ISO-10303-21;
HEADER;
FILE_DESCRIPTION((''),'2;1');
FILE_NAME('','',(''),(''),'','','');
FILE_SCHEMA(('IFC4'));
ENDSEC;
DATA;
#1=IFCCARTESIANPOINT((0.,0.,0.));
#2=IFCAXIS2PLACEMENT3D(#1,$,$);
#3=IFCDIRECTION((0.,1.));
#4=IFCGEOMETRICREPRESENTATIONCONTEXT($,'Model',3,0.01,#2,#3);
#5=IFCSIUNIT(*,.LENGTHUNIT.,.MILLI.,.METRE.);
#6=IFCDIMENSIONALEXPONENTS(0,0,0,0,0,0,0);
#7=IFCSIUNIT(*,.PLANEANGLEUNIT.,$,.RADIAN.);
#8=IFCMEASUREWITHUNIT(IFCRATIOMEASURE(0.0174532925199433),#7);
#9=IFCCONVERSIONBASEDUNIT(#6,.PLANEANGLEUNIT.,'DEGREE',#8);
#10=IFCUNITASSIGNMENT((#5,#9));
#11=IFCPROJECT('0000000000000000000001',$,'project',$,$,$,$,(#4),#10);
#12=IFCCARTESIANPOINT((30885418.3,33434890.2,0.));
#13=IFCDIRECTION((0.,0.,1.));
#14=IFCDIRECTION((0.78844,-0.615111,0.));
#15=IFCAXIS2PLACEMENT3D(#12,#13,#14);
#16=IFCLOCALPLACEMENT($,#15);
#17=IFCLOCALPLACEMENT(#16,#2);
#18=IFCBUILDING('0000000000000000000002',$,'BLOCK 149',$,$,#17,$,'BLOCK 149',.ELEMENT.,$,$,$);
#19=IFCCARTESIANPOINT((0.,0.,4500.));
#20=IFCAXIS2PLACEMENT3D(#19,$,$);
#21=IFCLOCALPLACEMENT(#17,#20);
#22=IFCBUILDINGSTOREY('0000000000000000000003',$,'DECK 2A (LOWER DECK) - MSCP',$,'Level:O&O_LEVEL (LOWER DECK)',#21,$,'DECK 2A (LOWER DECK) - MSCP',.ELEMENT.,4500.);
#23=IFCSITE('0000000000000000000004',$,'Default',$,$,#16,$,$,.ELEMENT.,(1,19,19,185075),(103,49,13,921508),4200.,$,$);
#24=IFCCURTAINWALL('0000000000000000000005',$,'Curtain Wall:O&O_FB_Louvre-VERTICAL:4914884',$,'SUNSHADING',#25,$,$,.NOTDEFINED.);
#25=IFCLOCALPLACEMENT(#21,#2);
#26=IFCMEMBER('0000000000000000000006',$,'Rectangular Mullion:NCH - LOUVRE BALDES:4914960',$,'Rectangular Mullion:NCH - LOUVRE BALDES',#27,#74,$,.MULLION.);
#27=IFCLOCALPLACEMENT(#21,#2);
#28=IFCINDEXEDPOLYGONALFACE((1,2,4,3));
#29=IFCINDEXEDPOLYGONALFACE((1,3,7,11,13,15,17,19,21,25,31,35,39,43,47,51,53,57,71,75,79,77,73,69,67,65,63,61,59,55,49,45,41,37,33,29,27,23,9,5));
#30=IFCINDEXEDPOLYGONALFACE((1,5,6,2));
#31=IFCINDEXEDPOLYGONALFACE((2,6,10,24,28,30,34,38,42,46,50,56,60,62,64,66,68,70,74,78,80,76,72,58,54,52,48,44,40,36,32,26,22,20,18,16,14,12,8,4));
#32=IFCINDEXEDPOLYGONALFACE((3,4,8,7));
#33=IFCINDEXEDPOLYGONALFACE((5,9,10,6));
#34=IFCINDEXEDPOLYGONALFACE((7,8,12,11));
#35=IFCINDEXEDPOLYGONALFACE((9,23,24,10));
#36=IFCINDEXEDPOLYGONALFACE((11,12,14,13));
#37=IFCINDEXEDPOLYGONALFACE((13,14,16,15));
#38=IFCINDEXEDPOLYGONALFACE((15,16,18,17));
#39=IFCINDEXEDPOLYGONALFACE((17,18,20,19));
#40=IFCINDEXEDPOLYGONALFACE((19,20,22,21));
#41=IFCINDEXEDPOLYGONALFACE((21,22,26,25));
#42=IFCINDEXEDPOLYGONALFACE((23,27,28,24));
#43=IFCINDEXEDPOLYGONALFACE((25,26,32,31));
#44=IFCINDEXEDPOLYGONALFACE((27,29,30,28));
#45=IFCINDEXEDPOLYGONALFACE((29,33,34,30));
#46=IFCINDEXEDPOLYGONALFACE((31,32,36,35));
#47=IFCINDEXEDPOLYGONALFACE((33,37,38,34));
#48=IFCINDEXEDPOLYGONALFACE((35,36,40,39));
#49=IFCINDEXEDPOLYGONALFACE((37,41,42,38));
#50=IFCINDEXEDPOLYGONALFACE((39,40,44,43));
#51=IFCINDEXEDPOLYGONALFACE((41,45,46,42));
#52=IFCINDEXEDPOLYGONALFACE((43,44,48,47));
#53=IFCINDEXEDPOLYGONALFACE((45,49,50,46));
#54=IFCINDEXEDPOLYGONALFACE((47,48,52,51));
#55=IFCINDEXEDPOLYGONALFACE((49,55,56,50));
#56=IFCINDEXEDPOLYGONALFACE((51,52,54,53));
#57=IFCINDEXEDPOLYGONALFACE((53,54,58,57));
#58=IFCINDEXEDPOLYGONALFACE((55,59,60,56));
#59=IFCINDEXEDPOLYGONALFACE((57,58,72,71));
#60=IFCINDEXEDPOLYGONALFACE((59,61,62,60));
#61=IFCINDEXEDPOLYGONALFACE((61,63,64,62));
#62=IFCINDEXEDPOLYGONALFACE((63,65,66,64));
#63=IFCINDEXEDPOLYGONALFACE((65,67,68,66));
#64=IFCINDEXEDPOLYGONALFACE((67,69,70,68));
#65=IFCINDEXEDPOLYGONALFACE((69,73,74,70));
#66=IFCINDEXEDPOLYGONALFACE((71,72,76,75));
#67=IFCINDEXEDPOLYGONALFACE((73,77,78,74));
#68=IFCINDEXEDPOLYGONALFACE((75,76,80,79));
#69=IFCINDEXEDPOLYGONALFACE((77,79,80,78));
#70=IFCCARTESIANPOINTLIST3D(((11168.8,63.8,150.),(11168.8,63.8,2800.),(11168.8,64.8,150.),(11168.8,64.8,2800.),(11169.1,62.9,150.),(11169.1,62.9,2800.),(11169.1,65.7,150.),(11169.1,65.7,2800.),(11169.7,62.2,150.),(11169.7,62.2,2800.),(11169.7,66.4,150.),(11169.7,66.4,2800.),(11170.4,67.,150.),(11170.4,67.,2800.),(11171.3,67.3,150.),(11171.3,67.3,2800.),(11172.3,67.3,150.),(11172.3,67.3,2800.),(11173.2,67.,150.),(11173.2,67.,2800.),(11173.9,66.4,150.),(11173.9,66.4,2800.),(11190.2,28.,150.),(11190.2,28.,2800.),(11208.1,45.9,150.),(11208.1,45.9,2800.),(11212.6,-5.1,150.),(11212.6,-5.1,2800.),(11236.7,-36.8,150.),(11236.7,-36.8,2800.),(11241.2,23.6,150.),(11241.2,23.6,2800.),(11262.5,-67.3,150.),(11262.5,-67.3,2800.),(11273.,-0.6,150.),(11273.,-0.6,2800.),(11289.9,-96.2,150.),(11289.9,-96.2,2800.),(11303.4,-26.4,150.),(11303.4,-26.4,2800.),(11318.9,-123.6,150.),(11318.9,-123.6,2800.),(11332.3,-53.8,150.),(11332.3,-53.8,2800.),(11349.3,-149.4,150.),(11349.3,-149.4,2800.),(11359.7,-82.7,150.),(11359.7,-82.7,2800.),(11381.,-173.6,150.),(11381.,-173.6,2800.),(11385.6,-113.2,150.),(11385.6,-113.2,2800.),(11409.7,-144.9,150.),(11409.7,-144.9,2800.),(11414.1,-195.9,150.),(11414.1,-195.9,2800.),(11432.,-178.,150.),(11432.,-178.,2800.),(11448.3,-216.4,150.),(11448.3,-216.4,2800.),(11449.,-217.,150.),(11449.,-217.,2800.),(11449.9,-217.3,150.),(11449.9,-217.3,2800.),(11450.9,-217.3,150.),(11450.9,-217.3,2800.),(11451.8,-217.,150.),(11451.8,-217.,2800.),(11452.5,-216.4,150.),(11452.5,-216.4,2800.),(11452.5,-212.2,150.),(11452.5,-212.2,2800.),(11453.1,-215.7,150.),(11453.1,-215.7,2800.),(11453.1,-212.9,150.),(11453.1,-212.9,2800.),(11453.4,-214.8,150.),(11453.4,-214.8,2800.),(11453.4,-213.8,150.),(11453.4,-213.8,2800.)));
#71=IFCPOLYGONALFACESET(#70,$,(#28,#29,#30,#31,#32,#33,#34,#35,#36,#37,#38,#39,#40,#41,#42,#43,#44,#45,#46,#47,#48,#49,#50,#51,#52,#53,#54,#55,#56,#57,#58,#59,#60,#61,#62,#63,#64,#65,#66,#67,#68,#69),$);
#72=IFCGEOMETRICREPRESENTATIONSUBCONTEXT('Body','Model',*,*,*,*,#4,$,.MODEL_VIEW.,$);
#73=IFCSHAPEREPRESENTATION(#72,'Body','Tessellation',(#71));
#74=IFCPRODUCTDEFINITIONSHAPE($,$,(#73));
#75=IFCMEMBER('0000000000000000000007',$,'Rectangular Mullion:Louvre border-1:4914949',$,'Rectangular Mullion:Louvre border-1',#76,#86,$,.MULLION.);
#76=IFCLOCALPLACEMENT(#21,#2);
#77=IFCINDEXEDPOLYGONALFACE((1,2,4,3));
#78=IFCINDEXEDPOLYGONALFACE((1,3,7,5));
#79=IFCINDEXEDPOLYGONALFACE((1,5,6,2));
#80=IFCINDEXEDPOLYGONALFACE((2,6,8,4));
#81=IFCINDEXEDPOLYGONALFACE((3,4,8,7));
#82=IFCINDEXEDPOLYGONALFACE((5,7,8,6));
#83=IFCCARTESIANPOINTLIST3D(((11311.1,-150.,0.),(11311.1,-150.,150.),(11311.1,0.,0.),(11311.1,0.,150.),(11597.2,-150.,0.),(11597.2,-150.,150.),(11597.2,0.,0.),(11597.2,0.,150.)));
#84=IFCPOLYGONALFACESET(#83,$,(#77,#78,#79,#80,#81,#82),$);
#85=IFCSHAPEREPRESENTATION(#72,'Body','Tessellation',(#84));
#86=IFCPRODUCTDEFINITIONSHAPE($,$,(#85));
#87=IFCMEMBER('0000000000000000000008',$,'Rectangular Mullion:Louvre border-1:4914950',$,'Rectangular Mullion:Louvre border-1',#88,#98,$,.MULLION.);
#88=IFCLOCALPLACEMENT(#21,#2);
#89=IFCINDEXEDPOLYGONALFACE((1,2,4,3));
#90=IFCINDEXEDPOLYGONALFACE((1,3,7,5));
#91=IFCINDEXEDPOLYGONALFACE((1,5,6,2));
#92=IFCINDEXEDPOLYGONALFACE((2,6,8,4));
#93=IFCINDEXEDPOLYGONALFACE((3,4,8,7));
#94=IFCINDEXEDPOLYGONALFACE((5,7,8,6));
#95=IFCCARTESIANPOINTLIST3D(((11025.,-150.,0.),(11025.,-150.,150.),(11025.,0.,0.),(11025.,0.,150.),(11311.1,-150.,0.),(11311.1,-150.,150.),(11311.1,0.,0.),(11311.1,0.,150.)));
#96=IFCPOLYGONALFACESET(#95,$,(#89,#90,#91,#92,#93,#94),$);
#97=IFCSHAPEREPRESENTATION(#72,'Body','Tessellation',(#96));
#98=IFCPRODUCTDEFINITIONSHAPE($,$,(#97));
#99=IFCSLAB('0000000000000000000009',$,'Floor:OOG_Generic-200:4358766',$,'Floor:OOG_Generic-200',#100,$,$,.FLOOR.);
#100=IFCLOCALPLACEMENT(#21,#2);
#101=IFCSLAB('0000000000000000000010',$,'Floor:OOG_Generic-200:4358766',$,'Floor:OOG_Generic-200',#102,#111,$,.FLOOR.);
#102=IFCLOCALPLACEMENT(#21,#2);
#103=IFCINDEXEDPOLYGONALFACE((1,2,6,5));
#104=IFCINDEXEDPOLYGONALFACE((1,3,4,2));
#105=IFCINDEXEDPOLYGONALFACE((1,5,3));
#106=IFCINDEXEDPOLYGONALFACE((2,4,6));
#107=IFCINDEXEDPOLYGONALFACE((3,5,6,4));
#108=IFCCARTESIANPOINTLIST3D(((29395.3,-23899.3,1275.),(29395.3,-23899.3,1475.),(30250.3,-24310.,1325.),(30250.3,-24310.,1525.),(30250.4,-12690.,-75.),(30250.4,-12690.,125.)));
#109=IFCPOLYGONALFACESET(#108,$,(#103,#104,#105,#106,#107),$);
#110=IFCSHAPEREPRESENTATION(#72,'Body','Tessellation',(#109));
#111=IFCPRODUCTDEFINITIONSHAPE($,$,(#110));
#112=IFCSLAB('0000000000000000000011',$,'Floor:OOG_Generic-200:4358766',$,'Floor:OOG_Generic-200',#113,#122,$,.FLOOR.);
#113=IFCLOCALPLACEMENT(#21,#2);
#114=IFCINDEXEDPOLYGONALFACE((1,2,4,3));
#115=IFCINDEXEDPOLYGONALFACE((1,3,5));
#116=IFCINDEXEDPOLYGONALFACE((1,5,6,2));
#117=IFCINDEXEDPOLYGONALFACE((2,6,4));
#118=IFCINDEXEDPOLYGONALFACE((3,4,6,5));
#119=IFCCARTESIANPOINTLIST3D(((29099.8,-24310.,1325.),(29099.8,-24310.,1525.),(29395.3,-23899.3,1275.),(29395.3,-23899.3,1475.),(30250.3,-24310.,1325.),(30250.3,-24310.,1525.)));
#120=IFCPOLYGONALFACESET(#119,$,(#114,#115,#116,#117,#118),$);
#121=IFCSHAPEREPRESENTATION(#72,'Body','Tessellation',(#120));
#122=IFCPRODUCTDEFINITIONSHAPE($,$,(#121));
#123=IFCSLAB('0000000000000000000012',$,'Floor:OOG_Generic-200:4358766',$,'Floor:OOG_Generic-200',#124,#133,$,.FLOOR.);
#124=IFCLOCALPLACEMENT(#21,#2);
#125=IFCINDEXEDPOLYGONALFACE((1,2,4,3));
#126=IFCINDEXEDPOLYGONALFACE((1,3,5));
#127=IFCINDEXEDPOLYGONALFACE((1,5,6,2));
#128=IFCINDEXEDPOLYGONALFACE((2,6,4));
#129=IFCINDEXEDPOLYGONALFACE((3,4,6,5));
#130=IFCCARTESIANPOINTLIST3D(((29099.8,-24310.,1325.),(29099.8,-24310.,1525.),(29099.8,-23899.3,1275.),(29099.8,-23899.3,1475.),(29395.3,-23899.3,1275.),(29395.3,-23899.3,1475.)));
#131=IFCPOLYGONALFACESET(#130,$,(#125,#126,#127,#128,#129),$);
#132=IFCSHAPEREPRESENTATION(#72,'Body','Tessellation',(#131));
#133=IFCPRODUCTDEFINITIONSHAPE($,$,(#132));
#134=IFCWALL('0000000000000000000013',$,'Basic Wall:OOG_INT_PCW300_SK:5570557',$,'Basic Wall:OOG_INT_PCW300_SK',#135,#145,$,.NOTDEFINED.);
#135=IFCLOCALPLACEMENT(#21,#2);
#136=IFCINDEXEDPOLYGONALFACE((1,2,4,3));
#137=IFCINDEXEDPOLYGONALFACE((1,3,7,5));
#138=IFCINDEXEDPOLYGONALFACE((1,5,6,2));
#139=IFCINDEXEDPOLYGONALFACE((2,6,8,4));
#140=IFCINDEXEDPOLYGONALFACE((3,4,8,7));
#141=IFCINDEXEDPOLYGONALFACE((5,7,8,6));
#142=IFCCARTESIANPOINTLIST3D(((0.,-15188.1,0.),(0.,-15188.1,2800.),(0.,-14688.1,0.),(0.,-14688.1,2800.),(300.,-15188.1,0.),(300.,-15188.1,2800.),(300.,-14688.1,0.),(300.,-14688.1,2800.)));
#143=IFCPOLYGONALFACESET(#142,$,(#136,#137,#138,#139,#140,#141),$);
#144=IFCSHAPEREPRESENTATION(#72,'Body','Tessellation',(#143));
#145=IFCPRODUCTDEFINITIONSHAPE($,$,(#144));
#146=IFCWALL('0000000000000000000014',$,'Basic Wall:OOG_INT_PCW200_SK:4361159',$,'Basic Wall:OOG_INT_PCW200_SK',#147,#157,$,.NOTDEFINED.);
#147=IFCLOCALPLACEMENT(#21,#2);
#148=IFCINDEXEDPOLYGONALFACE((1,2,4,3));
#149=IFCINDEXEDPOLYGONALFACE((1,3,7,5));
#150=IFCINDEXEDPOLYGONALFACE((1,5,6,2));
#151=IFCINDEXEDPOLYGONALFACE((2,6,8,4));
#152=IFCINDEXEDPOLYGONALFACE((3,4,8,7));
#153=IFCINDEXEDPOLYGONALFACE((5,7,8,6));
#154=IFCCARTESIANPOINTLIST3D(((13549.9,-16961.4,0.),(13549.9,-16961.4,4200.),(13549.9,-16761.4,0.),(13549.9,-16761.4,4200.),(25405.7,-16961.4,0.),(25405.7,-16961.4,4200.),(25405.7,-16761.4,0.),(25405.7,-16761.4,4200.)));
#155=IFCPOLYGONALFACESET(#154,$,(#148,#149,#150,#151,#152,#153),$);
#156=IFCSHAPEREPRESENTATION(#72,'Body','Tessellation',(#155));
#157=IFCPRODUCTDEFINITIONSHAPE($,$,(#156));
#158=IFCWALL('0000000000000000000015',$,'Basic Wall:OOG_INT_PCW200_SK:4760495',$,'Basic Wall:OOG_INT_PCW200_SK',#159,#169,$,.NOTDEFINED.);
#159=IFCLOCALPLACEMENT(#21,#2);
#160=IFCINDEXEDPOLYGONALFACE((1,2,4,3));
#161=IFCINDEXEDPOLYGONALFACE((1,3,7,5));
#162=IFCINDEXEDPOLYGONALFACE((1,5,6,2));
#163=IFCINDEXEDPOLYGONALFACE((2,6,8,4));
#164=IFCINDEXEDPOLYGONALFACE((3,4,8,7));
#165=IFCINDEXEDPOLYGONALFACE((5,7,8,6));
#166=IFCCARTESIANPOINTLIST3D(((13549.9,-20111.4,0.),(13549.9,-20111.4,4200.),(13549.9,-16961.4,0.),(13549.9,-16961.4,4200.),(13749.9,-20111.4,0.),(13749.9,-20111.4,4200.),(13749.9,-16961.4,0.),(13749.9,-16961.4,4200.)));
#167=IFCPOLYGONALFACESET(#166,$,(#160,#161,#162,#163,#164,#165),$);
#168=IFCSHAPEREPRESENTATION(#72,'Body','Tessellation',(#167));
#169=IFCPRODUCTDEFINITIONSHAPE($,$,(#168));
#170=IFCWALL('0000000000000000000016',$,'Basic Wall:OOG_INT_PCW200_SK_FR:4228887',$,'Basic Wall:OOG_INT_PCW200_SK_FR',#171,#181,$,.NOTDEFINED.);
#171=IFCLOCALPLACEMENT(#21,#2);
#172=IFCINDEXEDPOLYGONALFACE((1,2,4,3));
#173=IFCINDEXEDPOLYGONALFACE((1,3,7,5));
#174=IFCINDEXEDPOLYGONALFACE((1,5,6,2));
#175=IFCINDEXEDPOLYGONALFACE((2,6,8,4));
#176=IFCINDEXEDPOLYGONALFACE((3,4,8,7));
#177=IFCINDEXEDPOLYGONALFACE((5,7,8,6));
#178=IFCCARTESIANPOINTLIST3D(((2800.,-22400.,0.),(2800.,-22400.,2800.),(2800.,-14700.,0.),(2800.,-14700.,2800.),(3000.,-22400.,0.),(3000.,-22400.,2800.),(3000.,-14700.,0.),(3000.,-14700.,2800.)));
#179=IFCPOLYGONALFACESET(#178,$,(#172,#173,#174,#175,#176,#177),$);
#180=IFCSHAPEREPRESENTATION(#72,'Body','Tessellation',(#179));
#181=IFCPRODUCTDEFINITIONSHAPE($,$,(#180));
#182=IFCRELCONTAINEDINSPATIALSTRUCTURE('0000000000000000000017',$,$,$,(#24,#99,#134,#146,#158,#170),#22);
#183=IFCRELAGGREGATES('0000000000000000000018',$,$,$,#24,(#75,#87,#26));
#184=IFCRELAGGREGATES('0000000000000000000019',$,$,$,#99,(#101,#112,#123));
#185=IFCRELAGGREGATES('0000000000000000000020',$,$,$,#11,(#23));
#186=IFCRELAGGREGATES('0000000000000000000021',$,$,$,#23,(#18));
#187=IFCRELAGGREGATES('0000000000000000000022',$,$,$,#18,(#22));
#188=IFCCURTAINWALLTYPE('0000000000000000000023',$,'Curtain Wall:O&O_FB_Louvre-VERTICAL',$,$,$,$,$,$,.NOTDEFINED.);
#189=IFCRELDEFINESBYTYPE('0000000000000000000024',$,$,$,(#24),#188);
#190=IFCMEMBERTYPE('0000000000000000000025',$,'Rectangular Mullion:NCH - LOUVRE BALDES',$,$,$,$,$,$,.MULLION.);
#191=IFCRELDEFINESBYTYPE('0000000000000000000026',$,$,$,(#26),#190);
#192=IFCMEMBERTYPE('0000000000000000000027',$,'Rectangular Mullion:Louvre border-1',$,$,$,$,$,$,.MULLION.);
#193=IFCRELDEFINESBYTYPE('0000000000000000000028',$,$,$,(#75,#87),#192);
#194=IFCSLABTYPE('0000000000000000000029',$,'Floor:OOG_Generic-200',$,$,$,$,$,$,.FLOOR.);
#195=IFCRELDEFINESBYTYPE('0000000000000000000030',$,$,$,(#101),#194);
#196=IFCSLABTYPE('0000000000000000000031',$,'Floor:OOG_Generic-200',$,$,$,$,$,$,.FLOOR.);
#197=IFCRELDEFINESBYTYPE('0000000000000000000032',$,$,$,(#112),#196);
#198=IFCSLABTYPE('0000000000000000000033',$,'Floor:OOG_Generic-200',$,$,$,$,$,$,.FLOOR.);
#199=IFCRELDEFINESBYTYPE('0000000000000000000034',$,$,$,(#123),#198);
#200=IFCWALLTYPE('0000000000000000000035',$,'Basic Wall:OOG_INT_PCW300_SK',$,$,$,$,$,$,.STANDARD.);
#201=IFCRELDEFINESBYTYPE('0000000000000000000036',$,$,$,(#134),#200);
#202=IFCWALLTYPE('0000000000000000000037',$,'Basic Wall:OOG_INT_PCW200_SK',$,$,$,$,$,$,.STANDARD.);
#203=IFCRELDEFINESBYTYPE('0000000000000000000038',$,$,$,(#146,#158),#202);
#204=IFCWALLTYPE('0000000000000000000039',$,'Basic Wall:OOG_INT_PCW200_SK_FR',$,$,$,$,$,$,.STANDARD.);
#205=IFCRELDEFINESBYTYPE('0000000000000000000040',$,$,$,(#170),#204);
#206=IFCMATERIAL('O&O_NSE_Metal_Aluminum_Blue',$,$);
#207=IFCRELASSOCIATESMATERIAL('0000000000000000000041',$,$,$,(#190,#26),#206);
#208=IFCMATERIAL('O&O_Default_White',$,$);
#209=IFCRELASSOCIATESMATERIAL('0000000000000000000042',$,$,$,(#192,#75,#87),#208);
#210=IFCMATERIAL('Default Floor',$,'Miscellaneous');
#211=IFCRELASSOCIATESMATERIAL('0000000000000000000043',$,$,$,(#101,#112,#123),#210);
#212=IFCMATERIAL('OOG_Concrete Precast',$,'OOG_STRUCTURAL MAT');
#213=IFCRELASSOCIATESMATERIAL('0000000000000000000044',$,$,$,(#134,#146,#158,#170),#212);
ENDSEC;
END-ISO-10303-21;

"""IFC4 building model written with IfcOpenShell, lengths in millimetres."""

from ifc_helpers import new_model, entity, si_unit, converted_unit, direction, frame, origin, place, context, subcontext, project, spatial, indexed_curve, outline, extrude, source, transform, mapped, material, type_object, type_shapes, element, aggregate, save


model = new_model("IFC4")

# Units and contexts
model_context = context("Model", 3, precision=0.01, world=origin(), true_north=direction((0.0, 1.0)))
body_context = subcontext(model_context, "Body", "Model", "MODEL_VIEW")
ifc_project = project(units=[si_unit("LENGTHUNIT", "METRE", prefix="MILLI"), converted_unit("PLANEANGLEUNIT", "DEGREE", entity("IfcRatioMeasure", 0.0174532925199433), si_unit("PLANEANGLEUNIT", "RADIAN"), dimensions=[0, 0, 0, 0, 0, 0, 0])], contexts=[model_context])

# Site, building, storey
site_placement = place(None, frame((30885418.3, 33434890.2, 0.0), z_axis=(0.0, 0.0, 1.0), x_axis=(0.78844, -0.615111, 0.0)))
site = spatial("IfcSite", under=ifc_project, at=site_placement, Name="Default", CompositionType="ELEMENT", RefLatitude=(1, 19, 19, 185075), RefLongitude=(103, 49, 13, 921508), RefElevation=4200.0)
building_placement = place(site_placement, origin())
building = spatial("IfcBuilding", under=site, at=building_placement, Name="BLOCK 149", LongName="BLOCK 149", CompositionType="ELEMENT")
storey_placement = place(building_placement, frame((0.0, 0.0, 4500.0)))
storey = spatial("IfcBuildingStorey", under=building, at=storey_placement, Name="DECK 2A (LOWER DECK) - MSCP", ObjectType="Level:O&O_LEVEL (LOWER DECK)", LongName="DECK 2A (LOWER DECK) - MSCP", CompositionType="ELEMENT", Elevation=4500.0)

# Curtain wall, members
curtain_wall_type = type_object("IfcCurtainWallType", Name="Curtain Wall:O&O_FB_Louvre-VERTICAL", PredefinedType="NOTDEFINED")
curtain_wall_placement = place(storey_placement, frame((0.0, 0.0, -4500.0)))
curtain_wall = element("IfcCurtainWall", 1, at=curtain_wall_placement, inside=storey, type_object=curtain_wall_type, Name="Curtain Wall:O&O_FB_Louvre-VERTICAL:4914884", ObjectType="SUNSHADING", PredefinedType="NOTDEFINED")
ifc_material_1 = material(Name="O&O_NSE_Metal_Aluminum_Blue")
member_type_1 = type_object("IfcMemberType", Name="Rectangular Mullion:NCH - LOUVRE BALDES", PredefinedType="MULLION", material=ifc_material_1)
shared_shape_1 = source(origin(), body_context, "Body", "SweptSolid", [
    extrude(outline(indexed_curve([(55.9, -188.9), (54.8, -149.1), (51.6, -109.3), (46.1, -69.8), (38.6, -30.6), (28.9, 8.1), (17.1, 46.2), (3.3, 83.6), (-12.6, 120.2), (-30.4, 155.9), (-50.1, 190.5), (-50.5, 191.4), (-51.1, 192.1), (-52.0, 192.5), (-52.9, 192.7), (-53.8, 192.6), (-54.7, 192.2), (-55.4, 191.6), (-55.8, 190.8), (-56.0, 189.9), (-55.9, 188.9), (-54.8, 149.1), (-51.6, 109.3), (-46.1, 69.8), (-38.6, 30.6), (-28.9, -8.1), (-17.1, -46.2), (-3.3, -83.6), (12.6, -120.2), (30.4, -155.9), (50.1, -190.5), (50.5, -191.4), (51.1, -192.1), (52.0, -192.5), (52.9, -192.7), (53.8, -192.6), (54.7, -192.2), (55.4, -191.6), (55.8, -190.8), (56.0, -189.9), (55.9, -188.9)], self_intersect=False)), frame((0.0, 0.0, -2650.0), z_axis=(0.0, 0.0, 1.0), x_axis=(0.490779, -0.871284, 0.0)), (0.0, 0.0, 1.0), 2650.0),
])
type_shapes(member_type_1, [shared_shape_1])
member_1_placement = place(storey_placement, frame((11311.1, -75.0, 150.0), z_axis=(0.0, 0.0, -1.0), x_axis=(-1.0, 0.0, 0.0)))
member_1 = element("IfcMember", 2, at=member_1_placement, type_object=member_type_1, material=ifc_material_1, Name="Rectangular Mullion:NCH - LOUVRE BALDES:4914960", ObjectType="Rectangular Mullion:NCH - LOUVRE BALDES", PredefinedType="MULLION", context=body_context, shape_type="MappedRepresentation", body=[
    mapped(shared_shape_1, transform((0.0, 0.0, 0.0), scale=1.0)),
])
ifc_material_2 = material(Name="O&O_Default_White")
member_type_2 = type_object("IfcMemberType", Name="Rectangular Mullion:Louvre border-1", PredefinedType="MULLION", material=ifc_material_2)
shared_shape_2 = source(origin(), body_context, "Body", "SweptSolid", [
    extrude(outline(indexed_curve([(-75.0, -75.0), (75.0, -75.0), (75.0, 75.0), (-75.0, 75.0), (-75.0, -75.0)], self_intersect=False)), frame((-75.0, 0.0, -286.1), z_axis=(0.0, 0.0, 1.0), x_axis=(0.0, -1.0, 0.0)), (0.0, 0.0, 1.0), 286.1),
])
type_shapes(member_type_2, [shared_shape_2])
member_2_placement = place(storey_placement, frame((11597.2, -75.0, 0.0), z_axis=(1.0, 0.0, 0.0), x_axis=(0.0, 0.0, -1.0)))
member_2 = element("IfcMember", 3, at=member_2_placement, type_object=member_type_2, material=ifc_material_2, Name="Rectangular Mullion:Louvre border-1:4914949", ObjectType="Rectangular Mullion:Louvre border-1", PredefinedType="MULLION", context=body_context, shape_type="MappedRepresentation", body=[
    mapped(shared_shape_2, transform((0.0, 0.0, 0.0), scale=1.0)),
])
member_3_placement = place(storey_placement, frame((11311.1, -75.0, 0.0), z_axis=(1.0, 0.0, 0.0), x_axis=(0.0, 0.0, -1.0)))
member_3 = element("IfcMember", 4, at=member_3_placement, type_object=member_type_2, material=ifc_material_2, Name="Rectangular Mullion:Louvre border-1:4914950", ObjectType="Rectangular Mullion:Louvre border-1", PredefinedType="MULLION", context=body_context, shape_type="MappedRepresentation", body=[
    mapped(shared_shape_2, transform((0.0, 0.0, 0.0), scale=1.0)),
])
aggregate(curtain_wall, [member_2, member_3, member_1])

# Slabs
slab_1_placement = place(storey_placement, frame((29099.8, -24310.0, -75.0)))
slab_1 = element("IfcSlab", 5, at=slab_1_placement, inside=storey, Name="Floor:OOG_Generic-200:4358766", ObjectType="Floor:OOG_Generic-200", PredefinedType="FLOOR")
ifc_material_3 = material(Name="Default Floor", Category="Miscellaneous")
slab_type_1 = type_object("IfcSlabType", Name="Floor:OOG_Generic-200", PredefinedType="FLOOR")
slab_2_placement = place(slab_1_placement, origin())
slab_2 = element("IfcSlab", 6, at=slab_2_placement, type_object=slab_type_1, material=ifc_material_3, Name="Floor:OOG_Generic-200:4358766", ObjectType="Floor:OOG_Generic-200", PredefinedType="FLOOR", context=body_context, shape_type="SweptSolid", body=[
    extrude(outline(indexed_curve([(427.5, -5852.0), (427.5, 5852.0), (-427.5, -5438.2), (427.5, -5852.0)], self_intersect=False)), frame((723.0, 5810.0, 899.7), z_axis=(-0.000595, 0.119617, 0.99282), x_axis=(1.0, 0.000071, 0.000591)), (-0.000591, 0.119617, -0.99282), 200.0),
])
slab_type_2 = type_object("IfcSlabType", Name="Floor:OOG_Generic-200", PredefinedType="FLOOR")
slab_3_placement = place(slab_1_placement, origin())
slab_3 = element("IfcSlab", 7, at=slab_3_placement, type_object=slab_type_2, material=ifc_material_3, Name="Floor:OOG_Generic-200:4358766", ObjectType="Floor:OOG_Generic-200", PredefinedType="FLOOR", context=body_context, shape_type="SweptSolid", body=[
    extrude(outline(indexed_curve([(-575.2, 0.0), (575.2, 0.0), (-279.8, 413.8), (-575.2, 0.0)], self_intersect=False)), frame((575.2, 0.0, 1600.0), z_axis=(0.0, 0.120838, 0.992672), x_axis=(1.0, 0.0, 0.0)), (0.0, 0.120838, -0.992672), 200.0),
])
slab_type_3 = type_object("IfcSlabType", Name="Floor:OOG_Generic-200", PredefinedType="FLOOR")
slab_4_placement = place(slab_1_placement, origin())
slab_4 = element("IfcSlab", 8, at=slab_4_placement, type_object=slab_type_3, material=ifc_material_3, Name="Floor:OOG_Generic-200:4358766", ObjectType="Floor:OOG_Generic-200", PredefinedType="FLOOR", context=body_context, shape_type="SweptSolid", body=[
    extrude(outline(indexed_curve([(147.7, 206.9), (-147.7, 206.9), (-147.7, -206.9), (147.7, 206.9)], self_intersect=False)), frame((147.7, 205.4, 1575.0), z_axis=(0.0, 0.120838, 0.992672), x_axis=(1.0, 0.0, 0.0)), (0.0, 0.120838, -0.992672), 200.0),
])
aggregate(slab_1, [slab_2, slab_3, slab_4])

# Walls
ifc_material_4 = material(Name="OOG_Concrete Precast", Category="OOG_STRUCTURAL MAT")
wall_type_1 = type_object("IfcWallType", Name="Basic Wall:OOG_INT_PCW300_SK", PredefinedType="STANDARD")
wall_1_placement = place(storey_placement, frame((150.0, -15188.1, 0.0), z_axis=(0.0, 0.0, 1.0), x_axis=(0.0, 1.0, 0.0)))
element("IfcWall", 9, at=wall_1_placement, inside=storey, type_object=wall_type_1, material=ifc_material_4, Name="Basic Wall:OOG_INT_PCW300_SK:5570557", ObjectType="Basic Wall:OOG_INT_PCW300_SK", PredefinedType="NOTDEFINED", context=body_context, shape_type="SweptSolid", body=[
    extrude(outline(indexed_curve([(500.0, 150.0), (0.0, 150.0), (0.0, -150.0), (500.0, -150.0), (500.0, 150.0)], self_intersect=False)), origin(), (0.0, 0.0, 1.0), 2800.0),
])
wall_type_2 = type_object("IfcWallType", Name="Basic Wall:OOG_INT_PCW200_SK", PredefinedType="STANDARD")
wall_2_placement = place(storey_placement, frame((13549.9, -16861.4, 0.0)))
element("IfcWall", 10, at=wall_2_placement, inside=storey, type_object=wall_type_2, material=ifc_material_4, Name="Basic Wall:OOG_INT_PCW200_SK:4361159", ObjectType="Basic Wall:OOG_INT_PCW200_SK", PredefinedType="NOTDEFINED", context=body_context, shape_type="SweptSolid", body=[
    extrude(outline(indexed_curve([(11855.9, 100.0), (0.0, 100.0), (0.0, -100.0), (11855.9, -100.0), (11855.9, 100.0)], self_intersect=False)), origin(), (0.0, 0.0, 1.0), 4200.0),
])
wall_3_placement = place(storey_placement, frame((13649.9, -16961.4, 0.0), z_axis=(0.0, 0.0, 1.0), x_axis=(0.0, -1.0, 0.0)))
element("IfcWall", 11, at=wall_3_placement, inside=storey, type_object=wall_type_2, material=ifc_material_4, Name="Basic Wall:OOG_INT_PCW200_SK:4760495", ObjectType="Basic Wall:OOG_INT_PCW200_SK", PredefinedType="NOTDEFINED", context=body_context, shape_type="SweptSolid", body=[
    extrude(outline(indexed_curve([(3150.0, 100.0), (0.0, 100.0), (0.0, -100.0), (3150.0, -100.0), (3150.0, 100.0)], self_intersect=False)), origin(), (0.0, 0.0, 1.0), 4200.0),
])
wall_type_3 = type_object("IfcWallType", Name="Basic Wall:OOG_INT_PCW200_SK_FR", PredefinedType="STANDARD")
wall_4_placement = place(storey_placement, frame((2900.0, -14700.0, 0.0), z_axis=(0.0, 0.0, 1.0), x_axis=(0.0, -1.0, 0.0)))
element("IfcWall", 12, at=wall_4_placement, inside=storey, type_object=wall_type_3, material=ifc_material_4, Name="Basic Wall:OOG_INT_PCW200_SK_FR:4228887", ObjectType="Basic Wall:OOG_INT_PCW200_SK_FR", PredefinedType="NOTDEFINED", context=body_context, shape_type="SweptSolid", body=[
    extrude(outline(indexed_curve([(7700.0, 100.0), (0.0, 100.0), (0.0, -100.0), (7700.0, -100.0), (7700.0, 100.0)], self_intersect=False)), origin(), (0.0, 0.0, 1.0), 2800.0),
])

save(model, "model.ifc")
